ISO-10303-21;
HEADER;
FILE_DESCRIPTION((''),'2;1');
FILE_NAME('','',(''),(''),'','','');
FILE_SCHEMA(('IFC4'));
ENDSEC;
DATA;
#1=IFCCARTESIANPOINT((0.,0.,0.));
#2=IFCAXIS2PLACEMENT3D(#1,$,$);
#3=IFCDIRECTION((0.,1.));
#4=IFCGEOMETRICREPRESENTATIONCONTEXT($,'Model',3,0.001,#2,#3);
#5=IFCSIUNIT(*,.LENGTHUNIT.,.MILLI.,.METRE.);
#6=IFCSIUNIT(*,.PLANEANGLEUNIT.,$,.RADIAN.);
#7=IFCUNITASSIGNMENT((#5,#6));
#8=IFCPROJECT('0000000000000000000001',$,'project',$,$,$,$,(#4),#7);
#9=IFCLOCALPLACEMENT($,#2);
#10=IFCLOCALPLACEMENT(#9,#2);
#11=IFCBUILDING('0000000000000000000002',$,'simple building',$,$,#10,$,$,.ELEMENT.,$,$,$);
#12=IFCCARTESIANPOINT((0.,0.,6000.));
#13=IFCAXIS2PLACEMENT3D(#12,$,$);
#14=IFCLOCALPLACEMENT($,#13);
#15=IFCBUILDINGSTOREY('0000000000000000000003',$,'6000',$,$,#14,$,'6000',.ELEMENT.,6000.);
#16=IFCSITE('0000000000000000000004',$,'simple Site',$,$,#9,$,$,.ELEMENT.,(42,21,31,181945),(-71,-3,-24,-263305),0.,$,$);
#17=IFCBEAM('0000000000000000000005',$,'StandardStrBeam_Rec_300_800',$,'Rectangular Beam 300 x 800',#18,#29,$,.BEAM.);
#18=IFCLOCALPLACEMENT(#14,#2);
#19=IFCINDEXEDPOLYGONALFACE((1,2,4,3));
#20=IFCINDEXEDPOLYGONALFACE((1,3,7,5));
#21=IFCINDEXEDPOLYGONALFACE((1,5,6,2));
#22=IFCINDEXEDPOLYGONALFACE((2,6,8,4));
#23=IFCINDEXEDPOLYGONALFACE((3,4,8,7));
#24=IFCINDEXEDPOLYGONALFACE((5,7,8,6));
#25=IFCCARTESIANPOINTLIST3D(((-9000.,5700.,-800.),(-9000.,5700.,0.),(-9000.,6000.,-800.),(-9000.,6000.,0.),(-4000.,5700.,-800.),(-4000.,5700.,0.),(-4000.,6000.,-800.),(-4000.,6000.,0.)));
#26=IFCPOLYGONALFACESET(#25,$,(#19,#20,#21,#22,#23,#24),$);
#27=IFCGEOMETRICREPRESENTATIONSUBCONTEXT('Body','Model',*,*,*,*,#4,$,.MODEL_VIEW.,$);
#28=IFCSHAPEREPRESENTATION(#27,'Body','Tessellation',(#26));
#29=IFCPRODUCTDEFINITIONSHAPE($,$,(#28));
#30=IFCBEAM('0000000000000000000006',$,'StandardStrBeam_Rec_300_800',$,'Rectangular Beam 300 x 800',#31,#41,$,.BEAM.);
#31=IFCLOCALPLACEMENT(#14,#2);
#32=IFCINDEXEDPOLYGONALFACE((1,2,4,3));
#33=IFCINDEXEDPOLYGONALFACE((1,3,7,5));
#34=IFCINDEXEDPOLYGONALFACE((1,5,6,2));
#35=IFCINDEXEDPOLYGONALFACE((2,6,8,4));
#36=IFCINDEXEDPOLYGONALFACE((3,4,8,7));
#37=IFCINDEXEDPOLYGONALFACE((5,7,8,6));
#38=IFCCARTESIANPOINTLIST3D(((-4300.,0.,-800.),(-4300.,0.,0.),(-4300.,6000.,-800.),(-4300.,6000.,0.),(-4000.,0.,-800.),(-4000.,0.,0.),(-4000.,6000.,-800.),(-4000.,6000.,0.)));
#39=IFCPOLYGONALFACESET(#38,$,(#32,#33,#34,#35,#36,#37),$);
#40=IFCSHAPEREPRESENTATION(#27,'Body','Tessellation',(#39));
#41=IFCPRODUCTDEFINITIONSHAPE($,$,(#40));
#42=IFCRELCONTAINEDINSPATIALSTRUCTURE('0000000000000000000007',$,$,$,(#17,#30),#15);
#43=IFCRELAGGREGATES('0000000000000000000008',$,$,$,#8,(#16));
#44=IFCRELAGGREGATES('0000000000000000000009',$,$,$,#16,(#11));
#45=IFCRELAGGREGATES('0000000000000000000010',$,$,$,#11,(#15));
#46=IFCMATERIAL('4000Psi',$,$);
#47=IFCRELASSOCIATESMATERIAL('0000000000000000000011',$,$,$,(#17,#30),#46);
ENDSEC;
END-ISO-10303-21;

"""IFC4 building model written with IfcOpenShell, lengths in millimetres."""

from ifc_helpers import new_model, si_unit, direction, frame, origin, origin_with_axes, origin_2d_with_axis, place, context, subcontext, project, spatial, rectangle, extrude, material, material_profile, profile_set, profile_usage, element, save


model = new_model("IFC4")

# Units and contexts
model_context = context("Model", 3, precision=0.001, world=origin(), true_north=direction((0.0, 1.0)))
body_context = subcontext(model_context, "Body", "Model", "MODEL_VIEW")
ifc_project = project(units=[si_unit("LENGTHUNIT", "METRE", prefix="MILLI"), si_unit("PLANEANGLEUNIT", "RADIAN")], contexts=[model_context])

# Site, building, storey
site_placement = place(None, origin())
site = spatial("IfcSite", under=ifc_project, at=site_placement, Name="simple Site", CompositionType="ELEMENT", RefLatitude=(42, 21, 31, 181945), RefLongitude=(-71, -3, -24, -263305), RefElevation=0.0)
building_placement = place(site_placement, origin())
building = spatial("IfcBuilding", under=site, at=building_placement, Name="simple building", CompositionType="ELEMENT")
storey_placement = place(None, frame((0.0, 0.0, 6000.0)))
storey = spatial("IfcBuildingStorey", under=building, at=storey_placement, Name="6000", LongName="6000", CompositionType="ELEMENT", Elevation=6000.0)

# Beams
ifc_material = material(Name="4000Psi")
ifc_material_profile = material_profile(ifc_material, rectangle(XDim=300.0, YDim=800.0, at=origin_2d_with_axis()))
ifc_profile_set = profile_set([ifc_material_profile])
ifc_profile_usage_1 = profile_usage(ifc_profile_set, cardinal=7)
beam_1_placement = place(None, frame((-9000.0, 5850.0, 5600.0), z_axis=(1.0, 0.0, 0.0), x_axis=(0.0, -1.0, 0.0)))
element("IfcBeam", 1, at=beam_1_placement, inside=storey, material=ifc_profile_usage_1, Name="StandardStrBeam_Rec_300_800", ObjectType="Rectangular Beam 300 x 800", PredefinedType="BEAM", context=body_context, shape_type="SweptSolid", body=[
    extrude(rectangle(XDim=300.0, YDim=800.0, at=origin_2d_with_axis()), origin_with_axes(), (0.0, 0.0, 1.0), 5000.0),
])
ifc_profile_usage_2 = profile_usage(ifc_profile_set, cardinal=9)
beam_2_placement = place(None, frame((-4150.0, 0.0, 5600.0), z_axis=(0.0, 1.0, 0.0), x_axis=(1.0, 0.0, 0.0)))
element("IfcBeam", 2, at=beam_2_placement, inside=storey, material=ifc_profile_usage_2, Name="StandardStrBeam_Rec_300_800", ObjectType="Rectangular Beam 300 x 800", PredefinedType="BEAM", context=body_context, shape_type="SweptSolid", body=[
    extrude(rectangle(XDim=300.0, YDim=800.0, at=origin_2d_with_axis()), origin_with_axes(), (0.0, 0.0, 1.0), 6000.0),
])

save(model, "model.ifc")
